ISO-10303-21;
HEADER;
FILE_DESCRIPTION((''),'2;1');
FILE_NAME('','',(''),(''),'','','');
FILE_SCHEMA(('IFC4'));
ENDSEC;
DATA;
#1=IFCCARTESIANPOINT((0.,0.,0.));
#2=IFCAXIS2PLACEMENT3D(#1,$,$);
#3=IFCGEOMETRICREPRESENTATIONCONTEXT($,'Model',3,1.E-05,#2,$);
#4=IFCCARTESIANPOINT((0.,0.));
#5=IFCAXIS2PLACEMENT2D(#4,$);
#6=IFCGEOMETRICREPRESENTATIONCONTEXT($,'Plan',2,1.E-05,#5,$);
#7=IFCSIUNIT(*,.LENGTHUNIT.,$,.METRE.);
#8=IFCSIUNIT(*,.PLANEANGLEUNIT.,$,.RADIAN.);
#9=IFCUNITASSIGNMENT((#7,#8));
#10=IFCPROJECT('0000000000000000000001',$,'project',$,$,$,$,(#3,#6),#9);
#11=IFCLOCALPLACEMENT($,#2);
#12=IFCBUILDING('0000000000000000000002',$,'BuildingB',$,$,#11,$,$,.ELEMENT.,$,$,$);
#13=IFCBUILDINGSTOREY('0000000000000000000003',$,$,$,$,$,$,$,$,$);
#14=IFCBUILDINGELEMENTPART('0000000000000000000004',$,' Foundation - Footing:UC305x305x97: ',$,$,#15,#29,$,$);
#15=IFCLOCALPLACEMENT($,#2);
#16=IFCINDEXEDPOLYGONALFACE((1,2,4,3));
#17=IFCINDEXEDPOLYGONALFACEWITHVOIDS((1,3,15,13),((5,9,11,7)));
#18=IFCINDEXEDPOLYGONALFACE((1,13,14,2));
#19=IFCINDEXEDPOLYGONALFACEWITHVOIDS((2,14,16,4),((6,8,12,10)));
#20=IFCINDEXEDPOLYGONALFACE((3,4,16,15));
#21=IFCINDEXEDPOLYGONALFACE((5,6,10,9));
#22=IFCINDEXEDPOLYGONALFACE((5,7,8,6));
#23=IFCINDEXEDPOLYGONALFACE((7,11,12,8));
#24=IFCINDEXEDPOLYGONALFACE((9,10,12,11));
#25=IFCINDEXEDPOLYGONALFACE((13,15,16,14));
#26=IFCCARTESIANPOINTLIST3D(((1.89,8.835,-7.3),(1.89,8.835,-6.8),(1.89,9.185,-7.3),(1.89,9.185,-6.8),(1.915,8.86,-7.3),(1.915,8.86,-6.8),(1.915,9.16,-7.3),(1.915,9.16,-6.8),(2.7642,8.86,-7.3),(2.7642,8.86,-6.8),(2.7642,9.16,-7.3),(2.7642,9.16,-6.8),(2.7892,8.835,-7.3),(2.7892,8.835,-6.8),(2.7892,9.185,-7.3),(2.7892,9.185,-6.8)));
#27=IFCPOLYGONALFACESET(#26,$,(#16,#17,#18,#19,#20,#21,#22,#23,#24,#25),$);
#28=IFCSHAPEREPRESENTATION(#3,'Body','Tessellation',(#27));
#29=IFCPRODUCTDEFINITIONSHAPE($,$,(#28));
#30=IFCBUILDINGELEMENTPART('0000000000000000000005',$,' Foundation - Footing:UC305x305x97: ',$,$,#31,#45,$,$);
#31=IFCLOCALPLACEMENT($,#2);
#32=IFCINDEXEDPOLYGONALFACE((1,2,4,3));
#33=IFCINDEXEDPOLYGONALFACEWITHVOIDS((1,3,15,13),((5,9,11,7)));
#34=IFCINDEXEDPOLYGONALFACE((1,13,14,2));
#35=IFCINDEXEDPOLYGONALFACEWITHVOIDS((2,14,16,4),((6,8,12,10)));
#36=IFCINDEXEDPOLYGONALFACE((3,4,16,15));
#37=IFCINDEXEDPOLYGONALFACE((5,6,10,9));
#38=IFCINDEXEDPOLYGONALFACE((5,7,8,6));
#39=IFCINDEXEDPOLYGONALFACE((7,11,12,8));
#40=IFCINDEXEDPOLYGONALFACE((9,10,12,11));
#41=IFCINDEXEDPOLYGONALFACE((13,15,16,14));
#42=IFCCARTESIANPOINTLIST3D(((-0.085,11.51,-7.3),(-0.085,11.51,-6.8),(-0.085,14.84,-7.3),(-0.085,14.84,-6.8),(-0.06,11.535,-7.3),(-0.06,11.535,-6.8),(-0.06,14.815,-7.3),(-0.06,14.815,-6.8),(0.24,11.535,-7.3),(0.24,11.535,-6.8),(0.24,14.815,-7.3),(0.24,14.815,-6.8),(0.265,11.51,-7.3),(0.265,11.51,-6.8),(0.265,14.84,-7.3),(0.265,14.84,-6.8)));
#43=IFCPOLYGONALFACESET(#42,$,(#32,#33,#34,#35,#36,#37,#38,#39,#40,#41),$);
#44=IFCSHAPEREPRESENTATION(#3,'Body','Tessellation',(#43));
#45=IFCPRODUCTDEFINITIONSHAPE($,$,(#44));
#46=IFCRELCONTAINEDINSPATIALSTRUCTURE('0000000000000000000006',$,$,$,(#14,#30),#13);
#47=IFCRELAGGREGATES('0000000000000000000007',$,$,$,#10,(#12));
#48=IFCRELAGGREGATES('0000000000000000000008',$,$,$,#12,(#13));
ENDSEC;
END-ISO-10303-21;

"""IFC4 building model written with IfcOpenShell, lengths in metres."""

from ifc_helpers import new_model, si_unit, origin, origin_2d, place, context, project, spatial, polyline, outline, extrude, element, save


model = new_model("IFC4")

# Units and contexts
model_context = context("Model", 3, precision=1e-05, world=origin())
plan_context = context("Plan", 2, precision=1e-05, world=origin_2d())
ifc_project = project(units=[si_unit("LENGTHUNIT", "METRE"), si_unit("PLANEANGLEUNIT", "RADIAN")], contexts=[model_context, plan_context])

# Building, storey
building_placement = place(None, origin())
building = spatial("IfcBuilding", under=ifc_project, at=building_placement, Name="BuildingB", CompositionType="ELEMENT")
storey = spatial("IfcBuildingStorey", under=building)

# Building element parts, openings
building_element_part_1 = element("IfcBuildingElementPart", 1, inside=storey, Name=" Foundation - Footing:UC305x305x97: ", context=model_context, shape_type="SweptSolid", body=[
    extrude(outline(polyline([(1.89, 8.835, -7.3), (1.89, 9.185, -7.3), (2.7892, 9.185, -7.3), (2.7892, 8.835, -7.3), (1.89, 8.835, -7.3)])), None, (0.0, 0.0, 1.0), 0.5),
])
element("IfcOpeningElement", 2, inside=storey, cuts=building_element_part_1, context=model_context, shape_type="SweptSolid", body=[
    extrude(outline(polyline([(1.915, 8.86, -7.3), (1.915, 9.16, -7.3), (2.7642, 9.16, -7.3), (2.7642, 8.86, -7.3), (1.915, 8.86, -7.3)])), None, (0.0, 0.0, 1.0), 0.5),
])
building_element_part_2 = element("IfcBuildingElementPart", 3, inside=storey, Name=" Foundation - Footing:UC305x305x97: ", context=model_context, shape_type="SweptSolid", body=[
    extrude(outline(polyline([(-0.085, 11.51, -7.3), (-0.085, 14.84, -7.3), (0.265, 14.84, -7.3), (0.265, 11.51, -7.3), (-0.085, 11.51, -7.3)])), None, (0.0, 0.0, 1.0), 0.5),
])
element("IfcOpeningElement", 4, inside=storey, cuts=building_element_part_2, context=model_context, shape_type="SweptSolid", body=[
    extrude(outline(polyline([(-0.06, 11.535, -7.3), (-0.06, 14.815, -7.3), (0.24, 14.815, -7.3), (0.24, 11.535, -7.3), (-0.06, 11.535, -7.3)])), None, (0.0, 0.0, 1.0), 0.5),
])

save(model, "model.ifc")
